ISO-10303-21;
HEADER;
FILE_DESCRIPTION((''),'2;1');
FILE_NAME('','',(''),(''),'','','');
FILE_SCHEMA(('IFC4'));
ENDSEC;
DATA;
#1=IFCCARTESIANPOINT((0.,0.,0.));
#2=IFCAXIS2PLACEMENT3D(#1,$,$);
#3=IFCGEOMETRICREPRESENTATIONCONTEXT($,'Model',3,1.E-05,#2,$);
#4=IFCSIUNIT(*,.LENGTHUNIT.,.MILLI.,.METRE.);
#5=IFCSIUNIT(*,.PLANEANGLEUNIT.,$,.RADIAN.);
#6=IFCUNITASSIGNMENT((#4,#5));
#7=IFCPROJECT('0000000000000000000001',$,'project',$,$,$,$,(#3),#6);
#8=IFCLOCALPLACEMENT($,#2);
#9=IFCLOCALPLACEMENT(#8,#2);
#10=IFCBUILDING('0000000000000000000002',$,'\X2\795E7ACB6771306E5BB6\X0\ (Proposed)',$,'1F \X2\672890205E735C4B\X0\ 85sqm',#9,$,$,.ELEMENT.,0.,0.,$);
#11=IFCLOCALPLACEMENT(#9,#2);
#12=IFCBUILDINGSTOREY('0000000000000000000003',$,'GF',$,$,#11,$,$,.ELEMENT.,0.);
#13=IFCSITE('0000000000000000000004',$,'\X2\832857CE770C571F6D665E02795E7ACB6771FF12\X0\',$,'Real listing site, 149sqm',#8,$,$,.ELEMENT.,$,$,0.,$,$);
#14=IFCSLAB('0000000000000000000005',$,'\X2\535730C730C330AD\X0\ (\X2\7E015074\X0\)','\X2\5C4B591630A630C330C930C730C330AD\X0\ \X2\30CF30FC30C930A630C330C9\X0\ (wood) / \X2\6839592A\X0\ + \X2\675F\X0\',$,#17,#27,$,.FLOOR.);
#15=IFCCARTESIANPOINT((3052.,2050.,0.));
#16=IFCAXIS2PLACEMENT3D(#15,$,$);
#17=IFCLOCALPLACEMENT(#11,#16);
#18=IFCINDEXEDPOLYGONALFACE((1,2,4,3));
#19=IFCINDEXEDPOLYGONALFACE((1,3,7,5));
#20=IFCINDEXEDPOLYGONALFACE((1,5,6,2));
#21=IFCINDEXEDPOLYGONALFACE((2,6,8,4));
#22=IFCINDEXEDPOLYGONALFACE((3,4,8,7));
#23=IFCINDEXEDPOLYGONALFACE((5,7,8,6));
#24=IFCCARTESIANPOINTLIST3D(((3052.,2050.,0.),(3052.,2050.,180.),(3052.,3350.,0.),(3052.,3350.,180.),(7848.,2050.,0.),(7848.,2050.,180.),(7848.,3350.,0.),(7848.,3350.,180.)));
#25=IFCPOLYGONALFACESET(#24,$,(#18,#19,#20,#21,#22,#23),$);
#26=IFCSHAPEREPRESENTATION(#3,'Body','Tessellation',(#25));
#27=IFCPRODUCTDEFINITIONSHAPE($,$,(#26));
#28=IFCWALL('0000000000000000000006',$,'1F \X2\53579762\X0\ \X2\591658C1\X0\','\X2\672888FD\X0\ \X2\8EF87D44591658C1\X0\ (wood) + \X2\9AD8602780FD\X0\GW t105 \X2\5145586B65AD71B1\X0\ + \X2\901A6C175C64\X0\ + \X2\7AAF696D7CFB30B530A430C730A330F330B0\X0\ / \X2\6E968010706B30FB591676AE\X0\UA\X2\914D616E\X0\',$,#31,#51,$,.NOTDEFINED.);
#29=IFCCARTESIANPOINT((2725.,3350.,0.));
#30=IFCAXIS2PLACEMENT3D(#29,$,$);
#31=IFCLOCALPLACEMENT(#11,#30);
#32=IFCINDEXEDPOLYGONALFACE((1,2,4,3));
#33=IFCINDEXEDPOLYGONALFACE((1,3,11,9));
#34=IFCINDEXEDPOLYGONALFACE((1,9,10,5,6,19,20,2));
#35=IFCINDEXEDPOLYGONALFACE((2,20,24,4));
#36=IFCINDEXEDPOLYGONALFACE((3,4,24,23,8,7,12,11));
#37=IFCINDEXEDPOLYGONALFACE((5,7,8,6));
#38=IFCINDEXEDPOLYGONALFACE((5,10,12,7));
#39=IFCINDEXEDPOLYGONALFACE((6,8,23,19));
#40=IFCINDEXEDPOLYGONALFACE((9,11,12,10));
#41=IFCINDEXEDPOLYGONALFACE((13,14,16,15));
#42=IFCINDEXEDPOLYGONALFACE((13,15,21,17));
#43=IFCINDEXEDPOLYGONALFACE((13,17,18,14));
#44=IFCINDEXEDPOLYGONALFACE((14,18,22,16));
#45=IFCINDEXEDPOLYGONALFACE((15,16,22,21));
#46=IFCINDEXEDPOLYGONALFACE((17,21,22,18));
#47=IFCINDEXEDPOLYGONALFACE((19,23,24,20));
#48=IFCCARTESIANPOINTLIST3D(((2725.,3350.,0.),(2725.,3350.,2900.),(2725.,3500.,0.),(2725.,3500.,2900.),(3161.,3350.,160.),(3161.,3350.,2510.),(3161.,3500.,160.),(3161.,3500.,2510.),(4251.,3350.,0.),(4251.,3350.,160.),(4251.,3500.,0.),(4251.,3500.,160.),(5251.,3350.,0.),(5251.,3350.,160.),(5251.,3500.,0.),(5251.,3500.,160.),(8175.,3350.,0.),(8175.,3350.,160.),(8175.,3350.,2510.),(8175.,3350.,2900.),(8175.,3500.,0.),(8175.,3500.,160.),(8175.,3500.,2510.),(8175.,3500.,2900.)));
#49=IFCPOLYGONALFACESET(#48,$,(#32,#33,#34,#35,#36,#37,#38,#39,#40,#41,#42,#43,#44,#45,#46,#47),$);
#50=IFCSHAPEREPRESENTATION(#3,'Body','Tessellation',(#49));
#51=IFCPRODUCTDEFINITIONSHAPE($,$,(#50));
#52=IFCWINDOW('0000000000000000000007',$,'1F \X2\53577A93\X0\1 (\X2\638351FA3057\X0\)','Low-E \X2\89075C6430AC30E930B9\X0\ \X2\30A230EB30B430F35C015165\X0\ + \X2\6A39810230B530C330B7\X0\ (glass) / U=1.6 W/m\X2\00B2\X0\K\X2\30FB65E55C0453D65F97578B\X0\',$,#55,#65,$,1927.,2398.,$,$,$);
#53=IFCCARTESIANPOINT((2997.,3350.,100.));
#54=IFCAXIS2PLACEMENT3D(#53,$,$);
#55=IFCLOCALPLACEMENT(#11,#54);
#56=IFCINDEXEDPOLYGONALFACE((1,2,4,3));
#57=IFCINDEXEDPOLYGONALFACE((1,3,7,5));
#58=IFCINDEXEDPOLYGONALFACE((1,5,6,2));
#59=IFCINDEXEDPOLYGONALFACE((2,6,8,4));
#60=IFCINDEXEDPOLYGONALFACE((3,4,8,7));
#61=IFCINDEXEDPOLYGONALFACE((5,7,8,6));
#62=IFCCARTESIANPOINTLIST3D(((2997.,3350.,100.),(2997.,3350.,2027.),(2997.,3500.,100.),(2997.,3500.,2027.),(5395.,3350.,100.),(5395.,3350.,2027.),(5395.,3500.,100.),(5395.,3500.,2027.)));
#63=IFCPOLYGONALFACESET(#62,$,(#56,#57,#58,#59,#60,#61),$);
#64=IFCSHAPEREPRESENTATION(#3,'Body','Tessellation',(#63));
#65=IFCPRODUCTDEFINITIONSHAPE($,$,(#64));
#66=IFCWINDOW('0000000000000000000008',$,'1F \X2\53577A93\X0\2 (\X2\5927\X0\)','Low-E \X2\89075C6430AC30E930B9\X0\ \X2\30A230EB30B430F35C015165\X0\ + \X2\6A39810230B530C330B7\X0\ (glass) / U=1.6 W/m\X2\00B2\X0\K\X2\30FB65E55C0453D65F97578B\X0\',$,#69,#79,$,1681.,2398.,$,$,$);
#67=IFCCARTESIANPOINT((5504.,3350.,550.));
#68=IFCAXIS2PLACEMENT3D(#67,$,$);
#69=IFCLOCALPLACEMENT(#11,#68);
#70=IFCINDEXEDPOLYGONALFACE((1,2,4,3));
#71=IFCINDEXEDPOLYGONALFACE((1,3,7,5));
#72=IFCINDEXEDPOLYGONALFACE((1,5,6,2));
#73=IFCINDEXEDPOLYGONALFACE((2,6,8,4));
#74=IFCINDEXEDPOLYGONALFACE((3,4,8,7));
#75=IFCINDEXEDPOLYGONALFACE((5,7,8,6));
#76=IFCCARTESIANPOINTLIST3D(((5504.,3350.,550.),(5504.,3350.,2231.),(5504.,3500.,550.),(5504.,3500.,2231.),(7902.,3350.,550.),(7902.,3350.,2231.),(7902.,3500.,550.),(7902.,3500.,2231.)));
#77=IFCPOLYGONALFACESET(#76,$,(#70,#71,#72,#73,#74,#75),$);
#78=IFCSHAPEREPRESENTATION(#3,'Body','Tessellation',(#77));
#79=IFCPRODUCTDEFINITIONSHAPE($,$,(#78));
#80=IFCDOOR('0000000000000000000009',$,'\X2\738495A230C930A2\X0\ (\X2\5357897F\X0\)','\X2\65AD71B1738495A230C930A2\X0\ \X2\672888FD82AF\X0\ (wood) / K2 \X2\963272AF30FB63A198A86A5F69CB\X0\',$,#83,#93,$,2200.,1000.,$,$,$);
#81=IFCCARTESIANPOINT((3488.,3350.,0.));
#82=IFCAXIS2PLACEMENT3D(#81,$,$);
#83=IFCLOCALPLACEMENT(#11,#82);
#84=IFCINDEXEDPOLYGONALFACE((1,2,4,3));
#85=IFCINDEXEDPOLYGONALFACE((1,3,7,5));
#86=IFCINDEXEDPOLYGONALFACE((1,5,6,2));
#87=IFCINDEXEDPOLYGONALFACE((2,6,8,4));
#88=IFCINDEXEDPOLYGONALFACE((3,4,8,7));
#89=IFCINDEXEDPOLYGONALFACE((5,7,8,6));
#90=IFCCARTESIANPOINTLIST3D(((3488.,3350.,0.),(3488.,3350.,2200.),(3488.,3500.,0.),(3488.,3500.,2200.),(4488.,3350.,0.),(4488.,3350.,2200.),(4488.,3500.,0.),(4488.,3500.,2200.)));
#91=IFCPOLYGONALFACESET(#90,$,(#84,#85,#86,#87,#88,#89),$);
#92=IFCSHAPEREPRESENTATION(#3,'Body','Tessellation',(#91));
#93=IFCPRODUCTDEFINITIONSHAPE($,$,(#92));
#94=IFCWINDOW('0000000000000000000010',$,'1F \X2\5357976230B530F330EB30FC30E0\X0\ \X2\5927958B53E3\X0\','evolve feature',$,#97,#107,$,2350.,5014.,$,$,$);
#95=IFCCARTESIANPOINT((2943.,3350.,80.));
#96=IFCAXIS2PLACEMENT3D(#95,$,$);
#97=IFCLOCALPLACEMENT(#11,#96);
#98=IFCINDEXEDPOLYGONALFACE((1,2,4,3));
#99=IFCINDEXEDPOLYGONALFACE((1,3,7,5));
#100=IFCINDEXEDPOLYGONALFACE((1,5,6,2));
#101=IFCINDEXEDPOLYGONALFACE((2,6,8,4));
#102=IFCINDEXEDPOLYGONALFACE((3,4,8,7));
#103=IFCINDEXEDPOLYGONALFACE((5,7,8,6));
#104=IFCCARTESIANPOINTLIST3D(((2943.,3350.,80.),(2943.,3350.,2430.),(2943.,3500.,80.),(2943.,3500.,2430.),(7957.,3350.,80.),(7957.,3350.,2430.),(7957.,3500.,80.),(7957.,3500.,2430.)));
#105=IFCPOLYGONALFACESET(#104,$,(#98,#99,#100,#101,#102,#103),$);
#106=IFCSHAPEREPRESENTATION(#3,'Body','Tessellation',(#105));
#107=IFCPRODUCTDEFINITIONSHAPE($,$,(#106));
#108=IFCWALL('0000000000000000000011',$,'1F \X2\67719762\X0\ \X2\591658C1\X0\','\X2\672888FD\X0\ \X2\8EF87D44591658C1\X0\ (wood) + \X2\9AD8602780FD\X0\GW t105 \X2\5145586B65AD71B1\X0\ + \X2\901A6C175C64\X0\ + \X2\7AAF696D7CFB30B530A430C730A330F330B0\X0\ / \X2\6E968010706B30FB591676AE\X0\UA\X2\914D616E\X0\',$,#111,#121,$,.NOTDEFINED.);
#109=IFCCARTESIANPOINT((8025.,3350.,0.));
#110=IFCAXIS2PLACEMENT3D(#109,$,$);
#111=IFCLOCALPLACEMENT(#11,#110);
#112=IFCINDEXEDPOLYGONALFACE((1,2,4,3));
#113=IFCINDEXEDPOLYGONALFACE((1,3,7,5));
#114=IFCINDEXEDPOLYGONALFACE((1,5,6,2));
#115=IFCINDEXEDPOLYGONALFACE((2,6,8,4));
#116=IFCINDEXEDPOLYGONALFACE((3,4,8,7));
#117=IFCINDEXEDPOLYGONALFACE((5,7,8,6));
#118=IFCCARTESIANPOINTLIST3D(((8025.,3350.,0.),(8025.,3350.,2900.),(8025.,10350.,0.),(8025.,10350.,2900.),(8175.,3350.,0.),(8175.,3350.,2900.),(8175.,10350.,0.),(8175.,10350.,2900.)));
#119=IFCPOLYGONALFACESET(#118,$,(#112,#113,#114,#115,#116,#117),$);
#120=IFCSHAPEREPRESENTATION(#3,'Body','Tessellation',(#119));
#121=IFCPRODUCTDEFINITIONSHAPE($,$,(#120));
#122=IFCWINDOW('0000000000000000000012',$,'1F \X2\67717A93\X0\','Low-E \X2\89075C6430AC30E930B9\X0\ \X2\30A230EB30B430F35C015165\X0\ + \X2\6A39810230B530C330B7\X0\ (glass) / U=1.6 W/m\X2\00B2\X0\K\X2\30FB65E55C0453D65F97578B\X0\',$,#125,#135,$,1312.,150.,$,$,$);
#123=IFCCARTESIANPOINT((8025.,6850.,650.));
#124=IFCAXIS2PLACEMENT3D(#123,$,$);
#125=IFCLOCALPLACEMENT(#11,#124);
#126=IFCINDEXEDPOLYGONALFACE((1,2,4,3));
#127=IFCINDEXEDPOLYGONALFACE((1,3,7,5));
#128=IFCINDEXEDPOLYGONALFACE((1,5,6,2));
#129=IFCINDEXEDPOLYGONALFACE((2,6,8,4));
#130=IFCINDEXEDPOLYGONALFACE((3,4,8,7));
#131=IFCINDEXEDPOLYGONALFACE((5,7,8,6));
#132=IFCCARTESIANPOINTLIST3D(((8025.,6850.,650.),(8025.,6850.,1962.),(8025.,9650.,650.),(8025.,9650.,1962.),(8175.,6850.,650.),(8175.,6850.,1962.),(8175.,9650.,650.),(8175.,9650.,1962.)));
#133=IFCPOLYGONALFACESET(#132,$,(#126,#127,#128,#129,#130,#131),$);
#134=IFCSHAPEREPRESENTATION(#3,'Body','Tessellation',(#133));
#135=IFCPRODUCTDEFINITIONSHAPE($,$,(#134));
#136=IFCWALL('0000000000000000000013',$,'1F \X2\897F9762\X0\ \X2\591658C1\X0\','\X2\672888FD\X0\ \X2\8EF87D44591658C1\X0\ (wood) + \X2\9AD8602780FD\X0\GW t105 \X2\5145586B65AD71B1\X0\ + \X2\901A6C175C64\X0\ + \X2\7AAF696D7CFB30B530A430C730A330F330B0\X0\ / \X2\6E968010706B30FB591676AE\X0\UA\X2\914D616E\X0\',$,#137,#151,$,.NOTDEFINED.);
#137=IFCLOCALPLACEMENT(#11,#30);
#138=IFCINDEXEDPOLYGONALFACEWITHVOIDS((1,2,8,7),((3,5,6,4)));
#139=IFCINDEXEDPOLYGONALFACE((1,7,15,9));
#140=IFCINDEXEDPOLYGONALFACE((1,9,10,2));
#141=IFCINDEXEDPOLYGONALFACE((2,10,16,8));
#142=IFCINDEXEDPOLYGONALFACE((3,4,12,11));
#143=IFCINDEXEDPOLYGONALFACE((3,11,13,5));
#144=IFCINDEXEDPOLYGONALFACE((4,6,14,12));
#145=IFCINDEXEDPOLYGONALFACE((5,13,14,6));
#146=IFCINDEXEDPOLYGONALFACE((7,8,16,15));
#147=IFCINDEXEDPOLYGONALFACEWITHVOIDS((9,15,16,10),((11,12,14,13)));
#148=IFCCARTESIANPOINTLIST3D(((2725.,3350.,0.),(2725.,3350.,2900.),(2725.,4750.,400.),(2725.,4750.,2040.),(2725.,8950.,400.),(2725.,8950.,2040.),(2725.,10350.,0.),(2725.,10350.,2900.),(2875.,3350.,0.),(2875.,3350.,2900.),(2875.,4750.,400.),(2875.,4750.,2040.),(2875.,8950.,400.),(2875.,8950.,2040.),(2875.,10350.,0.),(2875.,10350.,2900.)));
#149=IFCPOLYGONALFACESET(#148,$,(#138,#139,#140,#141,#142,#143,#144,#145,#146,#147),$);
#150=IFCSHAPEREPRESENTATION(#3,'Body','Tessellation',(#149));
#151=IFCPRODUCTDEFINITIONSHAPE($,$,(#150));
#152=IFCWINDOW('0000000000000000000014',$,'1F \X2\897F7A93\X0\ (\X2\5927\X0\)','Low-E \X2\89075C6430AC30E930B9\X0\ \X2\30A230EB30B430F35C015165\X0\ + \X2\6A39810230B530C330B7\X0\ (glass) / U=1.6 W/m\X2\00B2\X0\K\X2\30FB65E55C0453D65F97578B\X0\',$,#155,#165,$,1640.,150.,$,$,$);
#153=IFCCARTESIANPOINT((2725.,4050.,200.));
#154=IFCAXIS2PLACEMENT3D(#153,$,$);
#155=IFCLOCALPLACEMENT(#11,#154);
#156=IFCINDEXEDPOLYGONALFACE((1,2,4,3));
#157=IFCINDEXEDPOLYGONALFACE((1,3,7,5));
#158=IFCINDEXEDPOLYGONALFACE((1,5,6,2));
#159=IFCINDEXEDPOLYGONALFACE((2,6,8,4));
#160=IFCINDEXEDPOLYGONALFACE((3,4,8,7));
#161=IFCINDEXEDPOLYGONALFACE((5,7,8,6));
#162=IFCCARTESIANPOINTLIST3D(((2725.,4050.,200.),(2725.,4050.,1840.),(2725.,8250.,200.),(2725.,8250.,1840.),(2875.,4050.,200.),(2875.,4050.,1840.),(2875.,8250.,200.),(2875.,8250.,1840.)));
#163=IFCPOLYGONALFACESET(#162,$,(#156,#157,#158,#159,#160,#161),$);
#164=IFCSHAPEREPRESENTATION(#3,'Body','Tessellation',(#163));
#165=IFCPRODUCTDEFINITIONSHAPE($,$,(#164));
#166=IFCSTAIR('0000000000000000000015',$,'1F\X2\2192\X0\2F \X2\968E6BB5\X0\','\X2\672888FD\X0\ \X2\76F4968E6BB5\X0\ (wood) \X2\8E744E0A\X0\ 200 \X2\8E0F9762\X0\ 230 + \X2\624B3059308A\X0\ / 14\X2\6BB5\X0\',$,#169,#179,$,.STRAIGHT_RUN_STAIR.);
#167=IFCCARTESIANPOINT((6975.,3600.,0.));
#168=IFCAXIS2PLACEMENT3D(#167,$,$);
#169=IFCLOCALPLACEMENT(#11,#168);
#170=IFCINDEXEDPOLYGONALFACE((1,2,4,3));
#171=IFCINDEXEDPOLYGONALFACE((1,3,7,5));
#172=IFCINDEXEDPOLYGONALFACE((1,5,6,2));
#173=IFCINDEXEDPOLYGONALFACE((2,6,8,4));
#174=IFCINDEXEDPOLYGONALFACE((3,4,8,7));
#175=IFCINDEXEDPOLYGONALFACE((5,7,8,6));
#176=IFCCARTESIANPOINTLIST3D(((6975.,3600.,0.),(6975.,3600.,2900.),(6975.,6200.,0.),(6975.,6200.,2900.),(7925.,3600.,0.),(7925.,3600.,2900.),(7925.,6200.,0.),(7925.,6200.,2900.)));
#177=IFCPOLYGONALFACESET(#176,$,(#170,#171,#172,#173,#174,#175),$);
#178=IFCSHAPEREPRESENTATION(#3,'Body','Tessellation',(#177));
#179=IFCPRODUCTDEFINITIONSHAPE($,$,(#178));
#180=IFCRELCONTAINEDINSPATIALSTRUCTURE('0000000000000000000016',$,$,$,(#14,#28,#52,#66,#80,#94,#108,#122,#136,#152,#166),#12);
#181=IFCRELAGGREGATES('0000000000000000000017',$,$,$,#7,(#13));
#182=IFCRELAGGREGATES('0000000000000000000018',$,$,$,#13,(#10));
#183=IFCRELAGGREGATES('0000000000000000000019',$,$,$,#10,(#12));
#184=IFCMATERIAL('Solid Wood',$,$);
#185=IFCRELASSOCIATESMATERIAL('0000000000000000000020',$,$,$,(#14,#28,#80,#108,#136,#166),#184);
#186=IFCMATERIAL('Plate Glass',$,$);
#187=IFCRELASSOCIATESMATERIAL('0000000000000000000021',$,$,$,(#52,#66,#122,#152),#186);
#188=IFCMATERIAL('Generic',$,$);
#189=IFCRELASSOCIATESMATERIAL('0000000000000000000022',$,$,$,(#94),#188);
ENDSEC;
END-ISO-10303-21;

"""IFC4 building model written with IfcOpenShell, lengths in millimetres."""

from ifc_helpers import new_model, si_unit, frame, frame_2d, origin, place, context, project, spatial, rectangle, extrude, material, element, fill, save


model = new_model("IFC4")

# Units and contexts
model_context = context("Model", 3, precision=1e-05, world=origin())
ifc_project = project(units=[si_unit("LENGTHUNIT", "METRE", prefix="MILLI"), si_unit("PLANEANGLEUNIT", "RADIAN")], contexts=[model_context])

# Site, building, storey
site_placement = place(None, origin())
site = spatial("IfcSite", under=ifc_project, at=site_placement, Name="茨城県土浦市神立東２", ObjectType="Real listing site, 149sqm", CompositionType="ELEMENT", RefElevation=0.0)
building_placement = place(site_placement, origin())
building = spatial("IfcBuilding", under=site, at=building_placement, Name="神立東の家 (Proposed)", ObjectType="1F 木造平屋 85sqm", CompositionType="ELEMENT", ElevationOfRefHeight=0.0, ElevationOfTerrain=0.0)
storey_placement = place(building_placement, origin())
storey = spatial("IfcBuildingStorey", under=building, at=storey_placement, Name="GF", CompositionType="ELEMENT", Elevation=0.0)

# Slab
ifc_material_1 = material(Name="Solid Wood")
slab_1_placement = place(storey_placement, frame((3052.0, 2050.0, 0.0)))
element("IfcSlab", 1, at=slab_1_placement, inside=storey, material=ifc_material_1, Name="南デッキ (縁側)", Description="屋外ウッドデッキ ハードウッド (wood) / 根太 + 束", PredefinedType="FLOOR", context=model_context, shape_type="SweptSolid", body=[
    extrude(rectangle(XDim=4796.0, YDim=1300.0, at=frame_2d((2398.0, 650.0))), frame((3052.0, 2050.0, 0.0)), (0.0, 0.0, 1.0), 180.0),
])
ifc_material_2 = material(Name="Generic")

# Wall, openings, windows, door
wall_1_placement = place(storey_placement, frame((2725.0, 3350.0, 0.0)))
wall_1 = element("IfcWall", 2, at=wall_1_placement, inside=storey, material=ifc_material_1, Name="1F 南面 外壁", Description="木製 軸組外壁 (wood) + 高性能GW t105 充填断熱 + 通気層 + 窯業系サイディング / 準耐火・外皮UA配慮", PredefinedType="NOTDEFINED", context=model_context, shape_type="SweptSolid", body=[
    extrude(rectangle(XDim=5450.0, YDim=150.0, at=frame_2d((2725.0, 75.0))), frame((2725.0, 3350.0, 0.0)), (0.0, 0.0, 1.0), 2900.0),
])
opening_1_placement = place(storey_placement, frame((2997.0, 3350.0, 100.0)))
opening_1 = element("IfcOpeningElement", 3, at=opening_1_placement, cuts=wall_1, PredefinedType="NOTDEFINED", context=model_context, shape_type="SweptSolid", body=[
    extrude(rectangle(XDim=2398.0, YDim=150.0, at=frame_2d((1199.0, 75.0))), frame((2997.0, 3350.0, 100.0)), (0.0, 0.0, 1.0), 1927.0),
])
opening_2_placement = place(storey_placement, frame((5504.0, 3350.0, 550.0)))
opening_2 = element("IfcOpeningElement", 4, at=opening_2_placement, cuts=wall_1, PredefinedType="NOTDEFINED", context=model_context, shape_type="SweptSolid", body=[
    extrude(rectangle(XDim=2398.0, YDim=150.0, at=frame_2d((1199.0, 75.0))), frame((5504.0, 3350.0, 550.0)), (0.0, 0.0, 1.0), 1681.0),
])
opening_3_placement = place(storey_placement, frame((3488.0, 3350.0, 0.0)))
opening_3 = element("IfcOpeningElement", 5, at=opening_3_placement, cuts=wall_1, PredefinedType="NOTDEFINED", context=model_context, shape_type="SweptSolid", body=[
    extrude(rectangle(XDim=1000.0, YDim=150.0, at=frame_2d((500.0, 75.0))), frame((3488.0, 3350.0, 0.0)), (0.0, 0.0, 1.0), 2200.0),
])
opening_4_placement = place(storey_placement, frame((2943.0, 3350.0, 80.0)))
opening_4 = element("IfcOpeningElement", 6, at=opening_4_placement, cuts=wall_1, PredefinedType="NOTDEFINED", context=model_context, shape_type="SweptSolid", body=[
    extrude(rectangle(XDim=5014.0, YDim=150.0, at=frame_2d((2507.0, 75.0))), frame((2943.0, 3350.0, 80.0)), (0.0, 0.0, 1.0), 2350.0),
])
ifc_material_3 = material(Name="Plate Glass")
window_1_placement = place(storey_placement, frame((2997.0, 3350.0, 100.0)))
window_1 = element("IfcWindow", 7, at=window_1_placement, inside=storey, material=ifc_material_3, Name="1F 南窓1 (掃出し)", Description="Low-E 複層ガラス アルゴン封入 + 樹脂サッシ (glass) / U=1.6 W/m²K・日射取得型", OverallHeight=1927.0, OverallWidth=2398.0, context=model_context, shape_type="SweptSolid", body=[
    extrude(rectangle(XDim=2398.0, YDim=150.0, at=frame_2d((1199.0, 75.0))), frame((2997.0, 3350.0, 100.0)), (0.0, 0.0, 1.0), 1927.0),
])
fill(opening_1, window_1)
window_2_placement = place(storey_placement, frame((5504.0, 3350.0, 550.0)))
window_2 = element("IfcWindow", 8, at=window_2_placement, inside=storey, material=ifc_material_3, Name="1F 南窓2 (大)", Description="Low-E 複層ガラス アルゴン封入 + 樹脂サッシ (glass) / U=1.6 W/m²K・日射取得型", OverallHeight=1681.0, OverallWidth=2398.0, context=model_context, shape_type="SweptSolid", body=[
    extrude(rectangle(XDim=2398.0, YDim=150.0, at=frame_2d((1199.0, 75.0))), frame((5504.0, 3350.0, 550.0)), (0.0, 0.0, 1.0), 1681.0),
])
fill(opening_2, window_2)
door_placement = place(storey_placement, frame((3488.0, 3350.0, 0.0)))
door = element("IfcDoor", 9, at=door_placement, inside=storey, material=ifc_material_1, Name="玄関ドア (南西)", Description="断熱玄関ドア 木製芯 (wood) / K2 防犯・採風機構", OverallHeight=2200.0, OverallWidth=1000.0, context=model_context, shape_type="SweptSolid", body=[
    extrude(rectangle(XDim=1000.0, YDim=150.0, at=frame_2d((500.0, 75.0))), frame((3488.0, 3350.0, 0.0)), (0.0, 0.0, 1.0), 2200.0),
])
fill(opening_3, door)
window_3_placement = place(storey_placement, frame((2943.0, 3350.0, 80.0)))
window_3 = element("IfcWindow", 10, at=window_3_placement, inside=storey, material=ifc_material_2, Name="1F 南面サンルーム 大開口", Description="evolve feature", OverallHeight=2350.0, OverallWidth=5014.0, context=model_context, shape_type="SweptSolid", body=[
    extrude(rectangle(XDim=5014.0, YDim=150.0, at=frame_2d((2507.0, 75.0))), frame((2943.0, 3350.0, 80.0)), (0.0, 0.0, 1.0), 2350.0),
])
fill(opening_4, window_3)

# Walls, openings, windows
wall_2_placement = place(storey_placement, frame((8025.0, 3350.0, 0.0)))
wall_2 = element("IfcWall", 11, at=wall_2_placement, inside=storey, material=ifc_material_1, Name="1F 東面 外壁", Description="木製 軸組外壁 (wood) + 高性能GW t105 充填断熱 + 通気層 + 窯業系サイディング / 準耐火・外皮UA配慮", PredefinedType="NOTDEFINED", context=model_context, shape_type="SweptSolid", body=[
    extrude(rectangle(XDim=150.0, YDim=7000.0, at=frame_2d((75.0, 3500.0))), frame((8025.0, 3350.0, 0.0)), (0.0, 0.0, 1.0), 2900.0),
])
opening_5_placement = place(storey_placement, frame((8025.0, 6850.0, 650.0)))
opening_5 = element("IfcOpeningElement", 12, at=opening_5_placement, cuts=wall_2, PredefinedType="NOTDEFINED", context=model_context, shape_type="SweptSolid", body=[
    extrude(rectangle(XDim=150.0, YDim=2800.0, at=frame_2d((75.0, 1400.0))), frame((8025.0, 6850.0, 650.0)), (0.0, 0.0, 1.0), 1312.0),
])
window_4_placement = place(storey_placement, frame((8025.0, 6850.0, 650.0)))
window_4 = element("IfcWindow", 13, at=window_4_placement, inside=storey, material=ifc_material_3, Name="1F 東窓", Description="Low-E 複層ガラス アルゴン封入 + 樹脂サッシ (glass) / U=1.6 W/m²K・日射取得型", OverallHeight=1312.0, OverallWidth=150.0, context=model_context, shape_type="SweptSolid", body=[
    extrude(rectangle(XDim=150.0, YDim=2800.0, at=frame_2d((75.0, 1400.0))), frame((8025.0, 6850.0, 650.0)), (0.0, 0.0, 1.0), 1312.0),
])
fill(opening_5, window_4)
wall_3_placement = place(storey_placement, frame((2725.0, 3350.0, 0.0)))
wall_3 = element("IfcWall", 14, at=wall_3_placement, inside=storey, material=ifc_material_1, Name="1F 西面 外壁", Description="木製 軸組外壁 (wood) + 高性能GW t105 充填断熱 + 通気層 + 窯業系サイディング / 準耐火・外皮UA配慮", PredefinedType="NOTDEFINED", context=model_context, shape_type="SweptSolid", body=[
    extrude(rectangle(XDim=150.0, YDim=7000.0, at=frame_2d((75.0, 3500.0))), frame((2725.0, 3350.0, 0.0)), (0.0, 0.0, 1.0), 2900.0),
])
opening_6_placement = place(storey_placement, frame((2725.0, 4050.0, 200.0)))
opening_6 = element("IfcOpeningElement", 15, at=opening_6_placement, cuts=wall_3, PredefinedType="NOTDEFINED", context=model_context, shape_type="SweptSolid", body=[
    extrude(rectangle(XDim=150.0, YDim=4200.0, at=frame_2d((75.0, 2100.0))), frame((2725.0, 4050.0, 200.0)), (0.0, 0.0, 1.0), 1640.0),
])
window_5_placement = place(storey_placement, frame((2725.0, 4050.0, 200.0)))
window_5 = element("IfcWindow", 16, at=window_5_placement, inside=storey, material=ifc_material_3, Name="1F 西窓 (大)", Description="Low-E 複層ガラス アルゴン封入 + 樹脂サッシ (glass) / U=1.6 W/m²K・日射取得型", OverallHeight=1640.0, OverallWidth=150.0, context=model_context, shape_type="SweptSolid", body=[
    extrude(rectangle(XDim=150.0, YDim=4200.0, at=frame_2d((75.0, 2100.0))), frame((2725.0, 4050.0, 200.0)), (0.0, 0.0, 1.0), 1640.0),
])
fill(opening_6, window_5)

# Stair
stair_placement = place(storey_placement, frame((6975.0, 3600.0, 0.0)))
element("IfcStair", 17, at=stair_placement, inside=storey, material=ifc_material_1, Name="1F→2F 階段", Description="木製 直階段 (wood) 蹴上 200 踏面 230 + 手すり / 14段", PredefinedType="STRAIGHT_RUN_STAIR", context=model_context, shape_type="SweptSolid", body=[
    extrude(rectangle(XDim=950.0, YDim=2600.0, at=frame_2d((475.0, 1300.0))), frame((6975.0, 3600.0, 0.0)), (0.0, 0.0, 1.0), 2900.0),
])

save(model, "model.ifc")
